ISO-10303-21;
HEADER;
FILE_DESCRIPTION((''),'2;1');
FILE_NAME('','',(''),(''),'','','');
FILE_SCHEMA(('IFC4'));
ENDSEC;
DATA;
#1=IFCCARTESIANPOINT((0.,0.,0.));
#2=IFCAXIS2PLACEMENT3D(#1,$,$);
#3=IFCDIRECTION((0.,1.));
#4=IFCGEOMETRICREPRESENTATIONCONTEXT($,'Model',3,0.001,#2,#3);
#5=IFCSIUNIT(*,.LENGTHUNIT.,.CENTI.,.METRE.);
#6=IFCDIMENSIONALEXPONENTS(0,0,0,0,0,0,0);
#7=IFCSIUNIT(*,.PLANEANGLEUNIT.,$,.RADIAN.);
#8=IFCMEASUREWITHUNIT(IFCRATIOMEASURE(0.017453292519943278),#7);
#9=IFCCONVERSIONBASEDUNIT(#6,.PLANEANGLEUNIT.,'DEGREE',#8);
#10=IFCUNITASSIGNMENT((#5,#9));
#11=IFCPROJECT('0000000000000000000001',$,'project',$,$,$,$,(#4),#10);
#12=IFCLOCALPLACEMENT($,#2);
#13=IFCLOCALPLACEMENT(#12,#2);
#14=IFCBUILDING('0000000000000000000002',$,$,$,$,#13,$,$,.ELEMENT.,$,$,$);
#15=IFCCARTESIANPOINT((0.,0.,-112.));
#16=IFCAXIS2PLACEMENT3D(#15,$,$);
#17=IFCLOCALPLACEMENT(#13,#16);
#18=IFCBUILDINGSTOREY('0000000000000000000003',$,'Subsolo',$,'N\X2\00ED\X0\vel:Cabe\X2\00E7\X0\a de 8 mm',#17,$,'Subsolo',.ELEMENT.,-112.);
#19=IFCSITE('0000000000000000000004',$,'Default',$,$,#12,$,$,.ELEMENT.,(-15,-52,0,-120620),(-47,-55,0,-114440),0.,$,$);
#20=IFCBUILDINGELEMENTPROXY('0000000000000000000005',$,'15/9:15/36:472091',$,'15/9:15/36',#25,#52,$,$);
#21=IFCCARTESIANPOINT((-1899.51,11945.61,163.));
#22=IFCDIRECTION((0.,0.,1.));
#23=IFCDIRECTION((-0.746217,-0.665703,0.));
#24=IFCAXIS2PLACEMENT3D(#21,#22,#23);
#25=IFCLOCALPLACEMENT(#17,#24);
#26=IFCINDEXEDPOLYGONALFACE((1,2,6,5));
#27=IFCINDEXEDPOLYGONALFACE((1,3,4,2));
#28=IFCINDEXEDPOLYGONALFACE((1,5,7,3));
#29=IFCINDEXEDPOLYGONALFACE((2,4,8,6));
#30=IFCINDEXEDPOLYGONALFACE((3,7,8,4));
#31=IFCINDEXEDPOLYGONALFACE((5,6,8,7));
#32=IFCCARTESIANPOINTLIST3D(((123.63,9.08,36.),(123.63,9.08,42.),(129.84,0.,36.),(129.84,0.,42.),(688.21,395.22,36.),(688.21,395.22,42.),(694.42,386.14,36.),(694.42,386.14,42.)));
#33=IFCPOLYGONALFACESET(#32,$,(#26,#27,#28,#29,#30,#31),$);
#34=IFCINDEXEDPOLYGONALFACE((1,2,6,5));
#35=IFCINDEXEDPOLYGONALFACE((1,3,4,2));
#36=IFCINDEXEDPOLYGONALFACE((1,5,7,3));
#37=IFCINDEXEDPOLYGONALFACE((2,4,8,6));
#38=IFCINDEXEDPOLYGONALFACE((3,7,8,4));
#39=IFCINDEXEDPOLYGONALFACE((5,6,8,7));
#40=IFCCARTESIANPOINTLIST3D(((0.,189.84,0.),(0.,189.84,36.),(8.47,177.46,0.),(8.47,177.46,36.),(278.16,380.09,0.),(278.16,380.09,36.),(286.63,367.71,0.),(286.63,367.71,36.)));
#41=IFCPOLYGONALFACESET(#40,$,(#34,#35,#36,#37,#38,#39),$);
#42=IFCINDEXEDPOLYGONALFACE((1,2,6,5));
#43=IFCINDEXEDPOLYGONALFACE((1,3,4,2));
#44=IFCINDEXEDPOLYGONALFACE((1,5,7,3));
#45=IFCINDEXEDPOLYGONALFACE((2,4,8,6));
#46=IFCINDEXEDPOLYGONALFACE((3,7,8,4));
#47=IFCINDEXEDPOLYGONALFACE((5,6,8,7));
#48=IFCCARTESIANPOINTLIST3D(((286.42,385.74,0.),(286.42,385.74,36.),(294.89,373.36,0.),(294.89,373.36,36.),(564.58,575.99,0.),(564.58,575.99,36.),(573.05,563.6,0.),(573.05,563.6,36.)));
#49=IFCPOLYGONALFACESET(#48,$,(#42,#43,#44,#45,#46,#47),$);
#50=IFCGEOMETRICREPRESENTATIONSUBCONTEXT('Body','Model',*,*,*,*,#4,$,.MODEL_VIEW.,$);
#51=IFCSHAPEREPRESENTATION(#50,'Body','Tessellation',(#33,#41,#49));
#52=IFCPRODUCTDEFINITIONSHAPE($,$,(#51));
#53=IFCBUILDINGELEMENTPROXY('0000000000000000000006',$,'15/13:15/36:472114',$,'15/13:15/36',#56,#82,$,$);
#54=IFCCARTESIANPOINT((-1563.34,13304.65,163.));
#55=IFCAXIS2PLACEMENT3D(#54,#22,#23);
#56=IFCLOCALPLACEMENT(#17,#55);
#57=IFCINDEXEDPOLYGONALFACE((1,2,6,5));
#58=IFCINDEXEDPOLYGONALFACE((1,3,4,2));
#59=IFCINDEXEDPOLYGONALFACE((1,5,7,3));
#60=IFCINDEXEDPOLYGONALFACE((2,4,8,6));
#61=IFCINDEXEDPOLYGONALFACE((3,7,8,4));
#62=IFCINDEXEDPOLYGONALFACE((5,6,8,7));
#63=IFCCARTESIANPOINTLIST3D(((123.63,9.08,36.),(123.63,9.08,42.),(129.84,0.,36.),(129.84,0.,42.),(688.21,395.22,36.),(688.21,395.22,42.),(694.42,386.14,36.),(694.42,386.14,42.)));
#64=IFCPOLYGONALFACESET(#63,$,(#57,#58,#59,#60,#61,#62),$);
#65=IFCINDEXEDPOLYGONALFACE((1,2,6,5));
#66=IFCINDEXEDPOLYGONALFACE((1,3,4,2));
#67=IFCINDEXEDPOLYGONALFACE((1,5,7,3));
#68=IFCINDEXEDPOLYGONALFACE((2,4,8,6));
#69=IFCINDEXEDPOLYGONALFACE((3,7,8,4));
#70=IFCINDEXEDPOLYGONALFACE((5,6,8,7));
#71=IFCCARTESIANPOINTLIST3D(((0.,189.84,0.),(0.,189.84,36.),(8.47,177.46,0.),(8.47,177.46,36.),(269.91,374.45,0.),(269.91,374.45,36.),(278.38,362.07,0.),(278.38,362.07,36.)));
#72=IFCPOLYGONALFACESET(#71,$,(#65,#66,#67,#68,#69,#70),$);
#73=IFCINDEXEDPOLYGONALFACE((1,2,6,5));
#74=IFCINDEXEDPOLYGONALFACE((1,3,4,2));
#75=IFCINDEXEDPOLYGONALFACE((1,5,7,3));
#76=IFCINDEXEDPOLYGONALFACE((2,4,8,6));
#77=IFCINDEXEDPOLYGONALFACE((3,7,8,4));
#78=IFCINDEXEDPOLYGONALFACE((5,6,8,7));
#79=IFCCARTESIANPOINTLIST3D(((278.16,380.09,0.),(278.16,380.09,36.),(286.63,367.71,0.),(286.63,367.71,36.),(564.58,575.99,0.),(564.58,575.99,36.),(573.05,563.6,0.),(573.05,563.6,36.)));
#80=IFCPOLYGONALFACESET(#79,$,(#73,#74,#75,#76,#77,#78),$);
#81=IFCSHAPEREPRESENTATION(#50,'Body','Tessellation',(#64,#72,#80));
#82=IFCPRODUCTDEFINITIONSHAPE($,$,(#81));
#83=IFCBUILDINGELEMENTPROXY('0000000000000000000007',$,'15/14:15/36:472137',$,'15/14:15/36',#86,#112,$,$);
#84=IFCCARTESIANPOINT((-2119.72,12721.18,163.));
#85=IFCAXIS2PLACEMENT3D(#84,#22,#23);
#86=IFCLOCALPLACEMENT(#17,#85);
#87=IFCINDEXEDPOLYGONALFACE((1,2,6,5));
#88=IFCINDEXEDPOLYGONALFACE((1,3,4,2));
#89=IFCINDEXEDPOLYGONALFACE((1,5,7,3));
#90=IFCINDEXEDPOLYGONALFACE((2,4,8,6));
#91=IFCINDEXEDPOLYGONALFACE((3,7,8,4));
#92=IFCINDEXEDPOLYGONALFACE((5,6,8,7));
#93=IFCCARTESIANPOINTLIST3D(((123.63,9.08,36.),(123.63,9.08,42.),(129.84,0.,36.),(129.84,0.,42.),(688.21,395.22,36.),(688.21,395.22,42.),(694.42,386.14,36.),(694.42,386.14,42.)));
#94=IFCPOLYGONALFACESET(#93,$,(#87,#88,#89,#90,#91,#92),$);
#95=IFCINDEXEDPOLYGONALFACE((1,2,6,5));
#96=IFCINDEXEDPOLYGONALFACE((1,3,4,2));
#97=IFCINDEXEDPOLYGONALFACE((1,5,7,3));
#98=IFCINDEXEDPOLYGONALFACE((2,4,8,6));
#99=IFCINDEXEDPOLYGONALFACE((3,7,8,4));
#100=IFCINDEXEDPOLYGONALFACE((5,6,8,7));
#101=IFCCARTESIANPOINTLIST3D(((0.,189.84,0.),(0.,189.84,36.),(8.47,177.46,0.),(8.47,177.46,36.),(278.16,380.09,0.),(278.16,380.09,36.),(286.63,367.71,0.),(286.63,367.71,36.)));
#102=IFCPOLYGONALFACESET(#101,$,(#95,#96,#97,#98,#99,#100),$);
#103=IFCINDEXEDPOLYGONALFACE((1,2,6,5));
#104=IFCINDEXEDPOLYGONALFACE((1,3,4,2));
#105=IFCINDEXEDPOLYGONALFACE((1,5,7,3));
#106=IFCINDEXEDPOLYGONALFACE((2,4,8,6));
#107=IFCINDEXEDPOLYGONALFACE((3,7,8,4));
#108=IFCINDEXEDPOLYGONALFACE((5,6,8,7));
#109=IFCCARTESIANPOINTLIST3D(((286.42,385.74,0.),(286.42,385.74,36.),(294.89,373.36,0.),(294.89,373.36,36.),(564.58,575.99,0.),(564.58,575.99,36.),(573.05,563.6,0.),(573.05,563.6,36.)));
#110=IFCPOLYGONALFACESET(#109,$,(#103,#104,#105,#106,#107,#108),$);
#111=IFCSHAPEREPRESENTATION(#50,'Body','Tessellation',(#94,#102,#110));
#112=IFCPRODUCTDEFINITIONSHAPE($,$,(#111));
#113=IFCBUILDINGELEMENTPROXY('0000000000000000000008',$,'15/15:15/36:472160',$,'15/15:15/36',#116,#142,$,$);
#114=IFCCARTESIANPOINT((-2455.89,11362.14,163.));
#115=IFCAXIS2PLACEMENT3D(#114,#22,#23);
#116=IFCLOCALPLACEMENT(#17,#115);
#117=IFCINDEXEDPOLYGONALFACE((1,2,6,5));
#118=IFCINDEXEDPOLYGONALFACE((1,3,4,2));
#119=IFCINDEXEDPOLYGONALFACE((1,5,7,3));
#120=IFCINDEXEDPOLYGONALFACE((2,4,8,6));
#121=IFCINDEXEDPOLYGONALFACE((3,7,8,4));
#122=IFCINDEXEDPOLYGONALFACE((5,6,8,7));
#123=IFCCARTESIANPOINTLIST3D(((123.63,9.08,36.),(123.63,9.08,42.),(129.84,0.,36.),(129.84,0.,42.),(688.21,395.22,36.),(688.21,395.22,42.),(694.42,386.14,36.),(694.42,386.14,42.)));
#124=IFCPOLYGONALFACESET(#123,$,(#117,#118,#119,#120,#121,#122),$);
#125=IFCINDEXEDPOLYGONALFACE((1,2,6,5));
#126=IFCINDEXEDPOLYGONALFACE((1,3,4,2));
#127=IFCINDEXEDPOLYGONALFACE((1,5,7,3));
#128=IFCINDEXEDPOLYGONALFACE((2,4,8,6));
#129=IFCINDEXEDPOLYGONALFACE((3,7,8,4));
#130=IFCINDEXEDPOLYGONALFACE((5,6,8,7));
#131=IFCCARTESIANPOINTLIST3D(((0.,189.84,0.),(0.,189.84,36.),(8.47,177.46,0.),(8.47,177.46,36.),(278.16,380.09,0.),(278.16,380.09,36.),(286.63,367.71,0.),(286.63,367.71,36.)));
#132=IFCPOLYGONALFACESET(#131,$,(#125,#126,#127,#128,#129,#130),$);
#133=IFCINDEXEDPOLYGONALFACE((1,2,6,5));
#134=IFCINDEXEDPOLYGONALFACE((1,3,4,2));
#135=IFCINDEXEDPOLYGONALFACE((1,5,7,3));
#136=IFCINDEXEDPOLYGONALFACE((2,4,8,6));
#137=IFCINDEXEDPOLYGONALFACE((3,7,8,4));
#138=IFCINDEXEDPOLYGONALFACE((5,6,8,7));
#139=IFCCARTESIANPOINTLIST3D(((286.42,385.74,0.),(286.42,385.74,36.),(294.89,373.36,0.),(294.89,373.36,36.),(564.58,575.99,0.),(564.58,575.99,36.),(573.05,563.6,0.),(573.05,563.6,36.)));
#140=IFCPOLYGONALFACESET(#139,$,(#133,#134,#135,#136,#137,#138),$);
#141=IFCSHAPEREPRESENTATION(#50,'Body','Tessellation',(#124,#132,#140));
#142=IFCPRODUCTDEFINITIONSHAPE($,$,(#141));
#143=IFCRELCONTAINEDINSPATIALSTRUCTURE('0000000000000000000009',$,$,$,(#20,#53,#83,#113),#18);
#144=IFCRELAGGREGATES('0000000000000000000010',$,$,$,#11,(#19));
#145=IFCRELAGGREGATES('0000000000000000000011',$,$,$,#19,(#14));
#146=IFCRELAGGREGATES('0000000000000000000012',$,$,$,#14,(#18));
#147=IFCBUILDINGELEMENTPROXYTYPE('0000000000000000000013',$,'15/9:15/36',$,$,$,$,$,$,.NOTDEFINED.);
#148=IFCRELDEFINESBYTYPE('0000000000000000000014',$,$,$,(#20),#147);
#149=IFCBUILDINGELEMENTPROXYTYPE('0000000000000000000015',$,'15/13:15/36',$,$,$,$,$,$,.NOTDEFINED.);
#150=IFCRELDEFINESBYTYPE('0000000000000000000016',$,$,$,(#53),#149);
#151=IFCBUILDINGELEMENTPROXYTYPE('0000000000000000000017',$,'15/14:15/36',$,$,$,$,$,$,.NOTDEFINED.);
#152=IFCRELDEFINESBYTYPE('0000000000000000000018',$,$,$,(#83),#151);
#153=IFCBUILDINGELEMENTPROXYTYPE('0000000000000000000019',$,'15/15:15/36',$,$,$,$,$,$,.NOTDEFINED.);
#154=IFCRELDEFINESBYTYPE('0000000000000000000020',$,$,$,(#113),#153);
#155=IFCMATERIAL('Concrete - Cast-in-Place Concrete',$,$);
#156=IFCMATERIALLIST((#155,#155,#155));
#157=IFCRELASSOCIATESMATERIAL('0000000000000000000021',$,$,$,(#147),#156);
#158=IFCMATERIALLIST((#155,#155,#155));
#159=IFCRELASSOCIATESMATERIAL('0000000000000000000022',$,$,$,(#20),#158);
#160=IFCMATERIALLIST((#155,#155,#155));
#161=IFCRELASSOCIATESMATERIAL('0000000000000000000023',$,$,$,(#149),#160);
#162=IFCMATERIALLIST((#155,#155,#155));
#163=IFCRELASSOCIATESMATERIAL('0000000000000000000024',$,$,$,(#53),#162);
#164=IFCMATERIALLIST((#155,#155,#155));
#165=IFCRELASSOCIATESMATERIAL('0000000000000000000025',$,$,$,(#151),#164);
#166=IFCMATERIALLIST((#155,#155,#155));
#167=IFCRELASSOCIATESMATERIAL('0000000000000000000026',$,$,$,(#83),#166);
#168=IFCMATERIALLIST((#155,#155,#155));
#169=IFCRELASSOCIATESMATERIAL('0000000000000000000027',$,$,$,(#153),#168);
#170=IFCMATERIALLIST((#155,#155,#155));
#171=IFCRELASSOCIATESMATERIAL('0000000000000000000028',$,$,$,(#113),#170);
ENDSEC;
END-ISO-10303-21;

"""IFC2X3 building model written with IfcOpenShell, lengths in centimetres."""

from ifc_helpers import new_model, entity, si_unit, converted_unit, direction, frame, frame_2d, origin, place, context, subcontext, project, spatial, rectangle, extrude, source, transform, mapped, material, material_list, type_object, type_shapes, element, save


model = new_model("IFC2X3")

# Units and contexts
model_context = context("Model", 3, precision=0.001, world=origin(), true_north=direction((0.0, 1.0)))
body_context = subcontext(model_context, "Body", "Model", "MODEL_VIEW")
ifc_project = project(units=[si_unit("LENGTHUNIT", "METRE", prefix="CENTI"), converted_unit("PLANEANGLEUNIT", "DEGREE", entity("IfcRatioMeasure", 0.017453292519943278), si_unit("PLANEANGLEUNIT", "RADIAN"), dimensions=[0, 0, 0, 0, 0, 0, 0])], contexts=[model_context])

# Site, building, storey
site_placement = place(None, origin())
site = spatial("IfcSite", under=ifc_project, at=site_placement, Name="Default", CompositionType="ELEMENT", RefLatitude=(-15, -52, 0, -120620), RefLongitude=(-47, -55, 0, -114440), RefElevation=0.0)
building_placement = place(site_placement, origin())
building = spatial("IfcBuilding", under=site, at=building_placement, CompositionType="ELEMENT")
storey_placement = place(building_placement, frame((0.0, 0.0, -112.0)))
storey = spatial("IfcBuildingStorey", under=building, at=storey_placement, Name="Subsolo", ObjectType="Nível:Cabeça de 8 mm", LongName="Subsolo", CompositionType="ELEMENT", Elevation=-112.0)

# Building element proxies
ifc_material_1 = material(Name="Concrete - Cast-in-Place Concrete")
ifc_material_list_1 = material_list([ifc_material_1, ifc_material_1, ifc_material_1])
ifc_material_list_2 = material_list([ifc_material_1, ifc_material_1, ifc_material_1])
building_element_proxy_type_1 = type_object("IfcBuildingElementProxyType", Name="15/9:15/36", PredefinedType="NOTDEFINED", material=ifc_material_list_2)
shared_shape_1 = source(origin(), body_context, "Body", "SweptSolid", [
    extrude(rectangle(XDim=11.0, YDim=684.0, at=frame_2d((0.0, 0.0), x_axis=(1.0, 0.0))), frame((409.03, 197.61, 36.0), z_axis=(0.0, 0.0, 1.0), x_axis=(-0.564535, 0.825409, 0.0)), (0.0, 0.0, 1.0), 6.0),
    extrude(rectangle(XDim=337.0, YDim=15.0, at=frame_2d((0.0, 0.0), x_axis=(1.0, 0.0))), frame((143.32, 278.78, 0.0), z_axis=(0.0, 0.0, 1.0), x_axis=(0.825409, 0.564535, 0.0)), (0.0, 0.0, 1.0), 36.0),
    extrude(rectangle(XDim=337.0, YDim=15.0, at=frame_2d((0.0, 0.0), x_axis=(1.0, 0.0))), frame((429.73, 474.67, 0.0), z_axis=(0.0, 0.0, 1.0), x_axis=(0.825409, 0.564535, 0.0)), (0.0, 0.0, 1.0), 36.0),
])
type_shapes(building_element_proxy_type_1, [shared_shape_1])
proxy_1_placement = place(storey_placement, frame((-1899.51, 11945.61, 163.0), z_axis=(0.0, 0.0, 1.0), x_axis=(-0.746217, -0.665703, 0.0)))
element("IfcBuildingElementProxy", 1, at=proxy_1_placement, inside=storey, type_object=building_element_proxy_type_1, material=ifc_material_list_1, Name="15/9:15/36:472091", ObjectType="15/9:15/36", context=body_context, shape_type="MappedRepresentation", body=[
    mapped(shared_shape_1, transform((0.0, 0.0, 0.0), scale=1.0)),
])
ifc_material_list_3 = material_list([ifc_material_1, ifc_material_1, ifc_material_1])
ifc_material_list_4 = material_list([ifc_material_1, ifc_material_1, ifc_material_1])
building_element_proxy_type_2 = type_object("IfcBuildingElementProxyType", Name="15/13:15/36", PredefinedType="NOTDEFINED", material=ifc_material_list_4)
shared_shape_2 = source(origin(), body_context, "Body", "SweptSolid", [
    extrude(rectangle(XDim=11.0, YDim=684.0, at=frame_2d((0.0, 0.0), x_axis=(1.0, 0.0))), frame((409.03, 197.61, 36.0), z_axis=(0.0, 0.0, 1.0), x_axis=(-0.564535, 0.825409, 0.0)), (0.0, 0.0, 1.0), 6.0),
    extrude(rectangle(XDim=327.0, YDim=15.0, at=frame_2d((0.0, 0.0), x_axis=(1.0, 0.0))), frame((139.19, 275.96, 0.0), z_axis=(0.0, 0.0, 1.0), x_axis=(0.825409, 0.564535, 0.0)), (0.0, 0.0, 1.0), 36.0),
    extrude(rectangle(XDim=347.0, YDim=15.0, at=frame_2d((0.0, 0.0), x_axis=(1.0, 0.0))), frame((425.61, 471.85, 0.0), z_axis=(0.0, 0.0, 1.0), x_axis=(0.825409, 0.564535, 0.0)), (0.0, 0.0, 1.0), 36.0),
])
type_shapes(building_element_proxy_type_2, [shared_shape_2])
proxy_2_placement = place(storey_placement, frame((-1563.34, 13304.65, 163.0), z_axis=(0.0, 0.0, 1.0), x_axis=(-0.746217, -0.665703, 0.0)))
element("IfcBuildingElementProxy", 2, at=proxy_2_placement, inside=storey, type_object=building_element_proxy_type_2, material=ifc_material_list_3, Name="15/13:15/36:472114", ObjectType="15/13:15/36", context=body_context, shape_type="MappedRepresentation", body=[
    mapped(shared_shape_2, transform((0.0, 0.0, 0.0), scale=1.0)),
])
ifc_material_list_5 = material_list([ifc_material_1, ifc_material_1, ifc_material_1])
ifc_material_list_6 = material_list([ifc_material_1, ifc_material_1, ifc_material_1])
building_element_proxy_type_3 = type_object("IfcBuildingElementProxyType", Name="15/14:15/36", PredefinedType="NOTDEFINED", material=ifc_material_list_6)
shared_shape_3 = source(origin(), body_context, "Body", "SweptSolid", [
    extrude(rectangle(XDim=11.0, YDim=684.0, at=frame_2d((0.0, 0.0), x_axis=(1.0, 0.0))), frame((409.03, 197.61, 36.0), z_axis=(0.0, 0.0, 1.0), x_axis=(-0.564535, 0.825409, 0.0)), (0.0, 0.0, 1.0), 6.0),
    extrude(rectangle(XDim=337.0, YDim=15.0, at=frame_2d((0.0, 0.0), x_axis=(1.0, 0.0))), frame((143.32, 278.78, 0.0), z_axis=(0.0, 0.0, 1.0), x_axis=(0.825409, 0.564535, 0.0)), (0.0, 0.0, 1.0), 36.0),
    extrude(rectangle(XDim=337.0, YDim=15.0, at=frame_2d((0.0, 0.0), x_axis=(1.0, 0.0))), frame((429.73, 474.67, 0.0), z_axis=(0.0, 0.0, 1.0), x_axis=(0.825409, 0.564535, 0.0)), (0.0, 0.0, 1.0), 36.0),
])
type_shapes(building_element_proxy_type_3, [shared_shape_3])
proxy_3_placement = place(storey_placement, frame((-2119.72, 12721.18, 163.0), z_axis=(0.0, 0.0, 1.0), x_axis=(-0.746217, -0.665703, 0.0)))
element("IfcBuildingElementProxy", 3, at=proxy_3_placement, inside=storey, type_object=building_element_proxy_type_3, material=ifc_material_list_5, Name="15/14:15/36:472137", ObjectType="15/14:15/36", context=body_context, shape_type="MappedRepresentation", body=[
    mapped(shared_shape_3, transform((0.0, 0.0, 0.0), scale=1.0)),
])
ifc_material_list_7 = material_list([ifc_material_1, ifc_material_1, ifc_material_1])
ifc_material_list_8 = material_list([ifc_material_1, ifc_material_1, ifc_material_1])
building_element_proxy_type_4 = type_object("IfcBuildingElementProxyType", Name="15/15:15/36", PredefinedType="NOTDEFINED", material=ifc_material_list_8)
shared_shape_4 = source(origin(), body_context, "Body", "SweptSolid", [
    extrude(rectangle(XDim=11.0, YDim=684.0, at=frame_2d((0.0, 0.0), x_axis=(1.0, 0.0))), frame((409.03, 197.61, 36.0), z_axis=(0.0, 0.0, 1.0), x_axis=(-0.564535, 0.825409, 0.0)), (0.0, 0.0, 1.0), 6.0),
    extrude(rectangle(XDim=337.0, YDim=15.0, at=frame_2d((0.0, 0.0), x_axis=(1.0, 0.0))), frame((143.32, 278.78, 0.0), z_axis=(0.0, 0.0, 1.0), x_axis=(0.825409, 0.564535, 0.0)), (0.0, 0.0, 1.0), 36.0),
    extrude(rectangle(XDim=337.0, YDim=15.0, at=frame_2d((0.0, 0.0), x_axis=(1.0, 0.0))), frame((429.73, 474.67, 0.0), z_axis=(0.0, 0.0, 1.0), x_axis=(0.825409, 0.564535, 0.0)), (0.0, 0.0, 1.0), 36.0),
])
type_shapes(building_element_proxy_type_4, [shared_shape_4])
proxy_4_placement = place(storey_placement, frame((-2455.89, 11362.14, 163.0), z_axis=(0.0, 0.0, 1.0), x_axis=(-0.746217, -0.665703, 0.0)))
element("IfcBuildingElementProxy", 4, at=proxy_4_placement, inside=storey, type_object=building_element_proxy_type_4, material=ifc_material_list_7, Name="15/15:15/36:472160", ObjectType="15/15:15/36", context=body_context, shape_type="MappedRepresentation", body=[
    mapped(shared_shape_4, transform((0.0, 0.0, 0.0), scale=1.0)),
])

save(model, "model.ifc")
